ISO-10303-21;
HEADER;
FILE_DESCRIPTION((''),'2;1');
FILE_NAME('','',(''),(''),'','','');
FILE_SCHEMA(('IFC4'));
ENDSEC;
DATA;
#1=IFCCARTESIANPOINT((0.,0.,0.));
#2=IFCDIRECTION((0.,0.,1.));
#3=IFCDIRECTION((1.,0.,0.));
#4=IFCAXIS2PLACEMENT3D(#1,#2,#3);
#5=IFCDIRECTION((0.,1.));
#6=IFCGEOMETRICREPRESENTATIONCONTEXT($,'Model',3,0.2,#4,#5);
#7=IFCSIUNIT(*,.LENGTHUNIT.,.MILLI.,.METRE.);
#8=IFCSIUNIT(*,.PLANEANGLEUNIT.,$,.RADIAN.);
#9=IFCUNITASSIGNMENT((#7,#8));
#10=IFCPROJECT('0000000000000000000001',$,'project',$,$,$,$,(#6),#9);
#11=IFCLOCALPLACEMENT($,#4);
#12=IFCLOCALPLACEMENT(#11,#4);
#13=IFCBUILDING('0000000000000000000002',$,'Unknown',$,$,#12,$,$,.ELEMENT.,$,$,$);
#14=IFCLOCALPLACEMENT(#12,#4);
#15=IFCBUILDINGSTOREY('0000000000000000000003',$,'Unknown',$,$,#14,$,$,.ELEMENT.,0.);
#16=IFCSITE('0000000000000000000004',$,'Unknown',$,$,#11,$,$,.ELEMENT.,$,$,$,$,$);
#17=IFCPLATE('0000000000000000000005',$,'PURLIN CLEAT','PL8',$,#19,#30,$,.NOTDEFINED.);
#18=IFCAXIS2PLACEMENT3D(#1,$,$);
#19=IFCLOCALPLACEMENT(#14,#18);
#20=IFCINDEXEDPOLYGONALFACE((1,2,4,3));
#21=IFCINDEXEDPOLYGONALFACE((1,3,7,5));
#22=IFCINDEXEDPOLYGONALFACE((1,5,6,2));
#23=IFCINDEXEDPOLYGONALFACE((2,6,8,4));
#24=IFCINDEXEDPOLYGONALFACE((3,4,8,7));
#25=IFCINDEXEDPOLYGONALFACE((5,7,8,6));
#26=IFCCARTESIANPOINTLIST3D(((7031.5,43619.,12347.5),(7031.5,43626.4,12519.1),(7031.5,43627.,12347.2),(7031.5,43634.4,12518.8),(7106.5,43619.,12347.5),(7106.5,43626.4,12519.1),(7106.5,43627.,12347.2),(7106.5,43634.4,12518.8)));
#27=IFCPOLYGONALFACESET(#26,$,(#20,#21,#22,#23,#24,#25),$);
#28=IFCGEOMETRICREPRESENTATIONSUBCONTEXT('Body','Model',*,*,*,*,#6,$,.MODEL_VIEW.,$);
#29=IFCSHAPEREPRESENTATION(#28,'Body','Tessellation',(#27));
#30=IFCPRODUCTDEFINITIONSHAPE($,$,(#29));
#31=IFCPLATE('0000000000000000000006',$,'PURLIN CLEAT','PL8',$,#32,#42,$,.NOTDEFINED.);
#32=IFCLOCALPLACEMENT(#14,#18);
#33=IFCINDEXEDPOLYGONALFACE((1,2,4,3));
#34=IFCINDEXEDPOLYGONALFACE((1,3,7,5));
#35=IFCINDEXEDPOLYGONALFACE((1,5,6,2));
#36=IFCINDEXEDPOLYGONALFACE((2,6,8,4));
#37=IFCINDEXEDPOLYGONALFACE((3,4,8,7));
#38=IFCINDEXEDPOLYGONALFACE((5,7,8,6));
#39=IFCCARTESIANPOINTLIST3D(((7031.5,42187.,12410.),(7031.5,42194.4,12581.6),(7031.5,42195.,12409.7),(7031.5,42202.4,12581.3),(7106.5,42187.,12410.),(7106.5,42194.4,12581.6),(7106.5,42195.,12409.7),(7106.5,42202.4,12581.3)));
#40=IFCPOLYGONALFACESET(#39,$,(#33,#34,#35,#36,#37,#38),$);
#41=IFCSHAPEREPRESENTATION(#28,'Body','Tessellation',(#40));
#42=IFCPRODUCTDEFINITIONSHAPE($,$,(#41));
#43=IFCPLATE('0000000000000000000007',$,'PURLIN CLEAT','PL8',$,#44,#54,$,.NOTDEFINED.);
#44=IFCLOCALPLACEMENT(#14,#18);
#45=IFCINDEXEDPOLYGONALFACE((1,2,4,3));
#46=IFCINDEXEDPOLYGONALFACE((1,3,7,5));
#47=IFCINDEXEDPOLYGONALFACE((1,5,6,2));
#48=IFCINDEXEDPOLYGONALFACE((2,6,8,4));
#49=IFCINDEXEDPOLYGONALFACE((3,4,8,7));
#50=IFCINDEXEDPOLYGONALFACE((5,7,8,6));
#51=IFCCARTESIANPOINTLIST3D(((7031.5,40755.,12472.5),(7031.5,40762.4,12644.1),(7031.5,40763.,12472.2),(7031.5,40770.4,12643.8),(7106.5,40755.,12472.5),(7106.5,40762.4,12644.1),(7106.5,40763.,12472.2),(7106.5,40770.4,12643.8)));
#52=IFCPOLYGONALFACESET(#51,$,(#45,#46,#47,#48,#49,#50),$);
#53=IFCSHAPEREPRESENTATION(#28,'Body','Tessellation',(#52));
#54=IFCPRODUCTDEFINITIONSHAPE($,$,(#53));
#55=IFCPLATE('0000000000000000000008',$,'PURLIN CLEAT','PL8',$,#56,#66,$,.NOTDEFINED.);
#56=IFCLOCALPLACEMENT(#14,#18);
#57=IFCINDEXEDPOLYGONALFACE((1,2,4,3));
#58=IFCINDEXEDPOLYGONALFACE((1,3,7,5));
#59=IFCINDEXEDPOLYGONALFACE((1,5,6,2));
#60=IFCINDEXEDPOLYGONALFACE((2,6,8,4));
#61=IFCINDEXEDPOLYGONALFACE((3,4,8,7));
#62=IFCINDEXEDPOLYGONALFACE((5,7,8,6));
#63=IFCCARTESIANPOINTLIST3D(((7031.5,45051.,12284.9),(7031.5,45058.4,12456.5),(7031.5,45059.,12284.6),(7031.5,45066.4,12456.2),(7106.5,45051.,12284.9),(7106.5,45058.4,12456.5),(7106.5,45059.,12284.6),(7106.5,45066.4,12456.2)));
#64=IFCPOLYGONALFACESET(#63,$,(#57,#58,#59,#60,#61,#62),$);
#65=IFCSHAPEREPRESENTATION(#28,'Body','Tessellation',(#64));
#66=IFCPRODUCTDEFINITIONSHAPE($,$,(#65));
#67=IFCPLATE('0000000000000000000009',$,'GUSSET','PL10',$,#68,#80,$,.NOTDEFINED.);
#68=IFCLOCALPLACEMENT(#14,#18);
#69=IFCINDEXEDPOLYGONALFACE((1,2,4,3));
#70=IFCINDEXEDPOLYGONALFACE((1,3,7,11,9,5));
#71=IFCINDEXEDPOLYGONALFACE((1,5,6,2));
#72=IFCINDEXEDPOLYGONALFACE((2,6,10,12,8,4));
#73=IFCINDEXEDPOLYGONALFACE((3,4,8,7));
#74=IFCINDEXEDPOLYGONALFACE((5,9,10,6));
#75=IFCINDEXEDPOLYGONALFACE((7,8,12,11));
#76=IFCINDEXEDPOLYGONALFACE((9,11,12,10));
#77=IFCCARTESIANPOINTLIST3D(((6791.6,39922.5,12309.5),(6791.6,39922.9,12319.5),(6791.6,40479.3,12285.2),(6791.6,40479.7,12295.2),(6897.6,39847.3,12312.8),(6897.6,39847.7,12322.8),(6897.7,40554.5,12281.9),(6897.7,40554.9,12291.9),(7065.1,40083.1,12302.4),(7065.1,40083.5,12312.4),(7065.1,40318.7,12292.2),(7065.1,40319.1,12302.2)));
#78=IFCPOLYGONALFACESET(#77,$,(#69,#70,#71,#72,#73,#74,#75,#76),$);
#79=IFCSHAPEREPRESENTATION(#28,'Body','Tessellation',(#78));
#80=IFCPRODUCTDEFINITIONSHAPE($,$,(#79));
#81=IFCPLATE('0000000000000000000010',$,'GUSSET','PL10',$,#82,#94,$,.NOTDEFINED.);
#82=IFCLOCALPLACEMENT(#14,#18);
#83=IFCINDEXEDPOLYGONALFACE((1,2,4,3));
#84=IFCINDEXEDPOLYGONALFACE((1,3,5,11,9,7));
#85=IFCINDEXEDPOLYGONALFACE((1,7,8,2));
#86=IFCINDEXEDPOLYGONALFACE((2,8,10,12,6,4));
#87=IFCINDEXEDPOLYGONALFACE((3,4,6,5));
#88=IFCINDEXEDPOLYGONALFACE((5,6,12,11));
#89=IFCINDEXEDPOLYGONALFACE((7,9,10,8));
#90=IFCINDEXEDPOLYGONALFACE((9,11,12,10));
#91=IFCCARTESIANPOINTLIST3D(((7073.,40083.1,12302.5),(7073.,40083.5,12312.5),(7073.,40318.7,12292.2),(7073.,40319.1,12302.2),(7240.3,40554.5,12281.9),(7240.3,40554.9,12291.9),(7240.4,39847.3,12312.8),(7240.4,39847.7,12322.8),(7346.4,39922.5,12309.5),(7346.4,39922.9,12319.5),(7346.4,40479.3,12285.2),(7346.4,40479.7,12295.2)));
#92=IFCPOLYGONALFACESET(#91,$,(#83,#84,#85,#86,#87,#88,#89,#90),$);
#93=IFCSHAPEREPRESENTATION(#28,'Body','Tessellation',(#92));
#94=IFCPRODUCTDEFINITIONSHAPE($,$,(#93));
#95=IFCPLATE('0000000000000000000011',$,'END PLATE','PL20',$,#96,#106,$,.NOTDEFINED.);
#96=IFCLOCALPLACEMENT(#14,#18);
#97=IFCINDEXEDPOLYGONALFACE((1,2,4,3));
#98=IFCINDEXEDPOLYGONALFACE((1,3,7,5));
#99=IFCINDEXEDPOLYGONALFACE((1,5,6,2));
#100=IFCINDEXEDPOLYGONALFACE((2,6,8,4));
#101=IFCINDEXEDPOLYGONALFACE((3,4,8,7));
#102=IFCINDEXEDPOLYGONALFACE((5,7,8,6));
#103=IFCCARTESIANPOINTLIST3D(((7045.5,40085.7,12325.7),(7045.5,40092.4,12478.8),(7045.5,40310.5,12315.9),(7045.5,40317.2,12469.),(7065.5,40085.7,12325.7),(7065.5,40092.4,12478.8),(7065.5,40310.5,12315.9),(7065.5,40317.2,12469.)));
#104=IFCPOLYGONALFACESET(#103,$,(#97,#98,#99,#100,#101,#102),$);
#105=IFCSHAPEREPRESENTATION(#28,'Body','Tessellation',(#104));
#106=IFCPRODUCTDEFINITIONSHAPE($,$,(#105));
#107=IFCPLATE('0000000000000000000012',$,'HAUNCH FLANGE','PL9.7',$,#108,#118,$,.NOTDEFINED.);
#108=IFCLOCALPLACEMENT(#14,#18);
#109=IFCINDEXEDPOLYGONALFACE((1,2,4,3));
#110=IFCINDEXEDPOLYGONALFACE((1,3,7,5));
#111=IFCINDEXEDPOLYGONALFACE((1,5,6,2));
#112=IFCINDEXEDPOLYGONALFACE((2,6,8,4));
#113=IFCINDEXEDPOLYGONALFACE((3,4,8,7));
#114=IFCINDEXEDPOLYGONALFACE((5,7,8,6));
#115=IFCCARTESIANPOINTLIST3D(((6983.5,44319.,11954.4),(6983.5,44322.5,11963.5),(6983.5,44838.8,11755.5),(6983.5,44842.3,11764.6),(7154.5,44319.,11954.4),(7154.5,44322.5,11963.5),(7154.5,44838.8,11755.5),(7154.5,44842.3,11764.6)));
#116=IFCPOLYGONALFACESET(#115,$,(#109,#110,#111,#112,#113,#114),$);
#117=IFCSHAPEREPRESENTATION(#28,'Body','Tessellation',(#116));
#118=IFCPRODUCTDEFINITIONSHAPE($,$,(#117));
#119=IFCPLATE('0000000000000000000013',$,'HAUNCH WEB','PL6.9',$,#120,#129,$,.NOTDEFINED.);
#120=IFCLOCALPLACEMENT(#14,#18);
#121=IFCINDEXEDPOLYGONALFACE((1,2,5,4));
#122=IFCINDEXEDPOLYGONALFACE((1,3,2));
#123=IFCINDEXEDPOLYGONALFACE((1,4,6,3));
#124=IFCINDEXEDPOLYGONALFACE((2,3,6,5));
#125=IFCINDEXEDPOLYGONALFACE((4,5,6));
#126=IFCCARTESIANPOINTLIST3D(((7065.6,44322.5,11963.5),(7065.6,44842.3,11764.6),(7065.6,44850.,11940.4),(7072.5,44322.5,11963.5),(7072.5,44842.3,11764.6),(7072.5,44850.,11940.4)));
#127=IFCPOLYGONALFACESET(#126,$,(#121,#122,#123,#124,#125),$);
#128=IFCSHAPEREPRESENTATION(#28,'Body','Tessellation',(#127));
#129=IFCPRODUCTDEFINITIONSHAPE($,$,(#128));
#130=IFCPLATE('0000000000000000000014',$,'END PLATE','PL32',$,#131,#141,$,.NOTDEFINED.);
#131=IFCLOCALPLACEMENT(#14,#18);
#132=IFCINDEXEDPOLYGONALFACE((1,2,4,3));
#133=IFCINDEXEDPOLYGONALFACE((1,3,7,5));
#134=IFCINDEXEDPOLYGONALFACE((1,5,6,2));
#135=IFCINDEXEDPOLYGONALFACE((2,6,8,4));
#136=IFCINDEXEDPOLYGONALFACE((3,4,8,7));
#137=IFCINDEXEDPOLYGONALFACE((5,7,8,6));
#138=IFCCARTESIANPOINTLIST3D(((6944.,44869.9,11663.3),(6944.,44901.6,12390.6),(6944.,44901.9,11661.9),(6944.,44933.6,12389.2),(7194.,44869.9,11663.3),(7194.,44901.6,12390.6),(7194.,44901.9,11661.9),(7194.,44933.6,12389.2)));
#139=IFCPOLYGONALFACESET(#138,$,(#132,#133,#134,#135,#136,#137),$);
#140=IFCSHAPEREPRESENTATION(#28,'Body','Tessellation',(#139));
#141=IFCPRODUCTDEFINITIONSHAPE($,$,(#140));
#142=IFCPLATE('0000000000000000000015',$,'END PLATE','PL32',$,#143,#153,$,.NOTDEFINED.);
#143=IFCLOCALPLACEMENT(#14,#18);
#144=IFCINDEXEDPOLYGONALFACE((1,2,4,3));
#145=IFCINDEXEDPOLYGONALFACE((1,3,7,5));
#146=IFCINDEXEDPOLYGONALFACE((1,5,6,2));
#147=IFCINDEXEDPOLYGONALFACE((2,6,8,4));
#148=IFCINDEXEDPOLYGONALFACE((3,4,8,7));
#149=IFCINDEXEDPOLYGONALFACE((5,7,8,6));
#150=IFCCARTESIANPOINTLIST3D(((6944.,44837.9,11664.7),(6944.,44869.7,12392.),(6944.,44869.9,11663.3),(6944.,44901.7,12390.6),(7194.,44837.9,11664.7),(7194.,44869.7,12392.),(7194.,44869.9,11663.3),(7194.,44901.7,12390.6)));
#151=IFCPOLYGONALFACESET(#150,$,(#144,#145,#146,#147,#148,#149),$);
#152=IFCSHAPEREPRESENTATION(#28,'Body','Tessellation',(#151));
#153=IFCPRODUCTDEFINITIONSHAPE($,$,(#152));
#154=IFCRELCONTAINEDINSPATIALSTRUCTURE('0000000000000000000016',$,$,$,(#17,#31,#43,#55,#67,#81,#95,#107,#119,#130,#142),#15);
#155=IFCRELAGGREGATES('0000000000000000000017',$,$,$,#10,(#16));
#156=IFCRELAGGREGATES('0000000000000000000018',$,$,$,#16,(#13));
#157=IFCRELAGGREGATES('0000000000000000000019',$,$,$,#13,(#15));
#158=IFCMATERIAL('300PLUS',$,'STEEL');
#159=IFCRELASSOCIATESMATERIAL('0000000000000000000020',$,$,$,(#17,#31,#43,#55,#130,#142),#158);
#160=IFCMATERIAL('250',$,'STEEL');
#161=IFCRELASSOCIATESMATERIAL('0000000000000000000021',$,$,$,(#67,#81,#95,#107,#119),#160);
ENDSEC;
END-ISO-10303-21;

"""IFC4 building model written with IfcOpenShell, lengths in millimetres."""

from ifc_helpers import new_model, si_unit, direction, frame, origin_with_axes, place, context, subcontext, project, spatial, line, indexed_curve, outline, extrude, material, element, save


model = new_model("IFC4")

# Units and contexts
model_context = context("Model", 3, precision=0.2, world=origin_with_axes(), true_north=direction((0.0, 1.0)))
body_context = subcontext(model_context, "Body", "Model", "MODEL_VIEW")
ifc_project = project(units=[si_unit("LENGTHUNIT", "METRE", prefix="MILLI"), si_unit("PLANEANGLEUNIT", "RADIAN")], contexts=[model_context])

# Site, building, storey
site_placement = place(None, origin_with_axes())
site = spatial("IfcSite", under=ifc_project, at=site_placement, Name="Unknown", CompositionType="ELEMENT")
building_placement = place(site_placement, origin_with_axes())
building = spatial("IfcBuilding", under=site, at=building_placement, Name="Unknown", CompositionType="ELEMENT")
storey_placement = place(building_placement, origin_with_axes())
storey = spatial("IfcBuildingStorey", under=building, at=storey_placement, Name="Unknown", CompositionType="ELEMENT", Elevation=0.0)

# Shared definitions
ifc_material_1 = material(Name="300PLUS", Category="STEEL")

# Plates
for number, where, z_axis, x_axis, name in (
    (1, (7031.5, 43623.0, 12347.4), (0.0, -0.999071, 0.043084), (1.0, 0.0, 0.0), "PURLIN CLEAT"),
    (2, (7031.5, 42191.0, 12409.9), (0.0, -0.999071, 0.043084), (1.0, 0.0, 0.0), "PURLIN CLEAT"),
    (3, (7031.5, 40759.0, 12472.4), (0.0, -0.999071, 0.043084), (1.0, 0.0, 0.0), "PURLIN CLEAT"),
    (4, (7031.5, 45055.0, 12284.8), (0.0, -0.999071, 0.043084), (1.0, 0.0, 0.0), "PURLIN CLEAT"),
):
    element("IfcPlate", number, at=place(storey_placement, frame(where, z_axis=z_axis, x_axis=x_axis)), inside=storey, material=ifc_material_1, Name=name, Description="PL8", PredefinedType="NOTDEFINED", context=body_context, shape_type="SolidModel", body=[
        extrude(outline(indexed_curve([(0.0, 0.0), (75.0, 0.0), (75.0, 171.8), (0.0, 171.8)], segments=[line(1, 2, 3, 4, 1)])), frame((0.0, 0.0, 4.0), z_axis=(0.0, 0.0, 1.0), x_axis=(1.0, 0.0, 0.0)), (0.0, 0.0, -1.0), 8.0),
    ])
ifc_material_2 = material(Name="250", Category="STEEL")
plate_1_placement = place(storey_placement, frame((6791.6, 40479.5, 12290.2), z_axis=(0.00017, 0.043601, 0.999049), x_axis=(0.0, -0.999049, 0.043601)))
element("IfcPlate", 5, at=plate_1_placement, inside=storey, material=ifc_material_2, Name="GUSSET", Description="PL10", PredefinedType="NOTDEFINED", context=body_context, shape_type="SolidModel", body=[
    extrude(outline(indexed_curve([(0.0, 0.0), (557.3, 0.0), (632.6, 106.0), (396.6, 273.5), (160.8, 273.5), (-75.3, 106.1)], segments=[line(1, 2, 3, 4, 5, 6, 1)])), frame((0.0, 0.0, 5.0), z_axis=(0.0, 0.0, 1.0), x_axis=(1.0, 0.0, 0.0)), (0.0, 0.0, -1.0), 10.0),
])
plate_2_placement = place(storey_placement, frame((7073.0, 40318.9, 12297.2), z_axis=(-0.000052, 0.043676, 0.999046), x_axis=(0.0, -0.999046, 0.043676)))
element("IfcPlate", 6, at=plate_2_placement, inside=storey, material=ifc_material_2, Name="GUSSET", Description="PL10", PredefinedType="NOTDEFINED", context=body_context, shape_type="SolidModel", body=[
    extrude(outline(indexed_curve([(0.0, 0.0), (235.8, 0.0), (471.8, 167.4), (396.6, 273.4), (-160.8, 273.4), (-236.0, 167.3)], segments=[line(1, 2, 3, 4, 5, 6, 1)])), frame((0.0, 0.0, 5.0), z_axis=(0.0, 0.0, 1.0), x_axis=(1.0, 0.0, 0.0)), (0.0, 0.0, -1.0), 10.0),
])
plate_3_placement = place(storey_placement, frame((7055.5, 40310.5, 12315.9), z_axis=(-1.0, 0.0, 0.0), x_axis=(0.0, -0.999051, 0.043553)))
element("IfcPlate", 7, at=plate_3_placement, inside=storey, material=ifc_material_2, Name="END PLATE", Description="PL20", PredefinedType="NOTDEFINED", context=body_context, shape_type="SolidModel", body=[
    extrude(outline(indexed_curve([(0.0, 0.0), (225.0, 0.0), (225.0, 153.2), (0.0, 153.2)], segments=[line(1, 2, 3, 4, 1)])), frame((0.0, 0.0, 10.0), z_axis=(0.0, 0.0, 1.0), x_axis=(1.0, 0.0, 0.0)), (0.0, 0.0, -1.0), 20.0),
])
plate_4_placement = place(storey_placement, frame((6983.5, 44840.5, 11760.0), z_axis=(0.0, 0.357377, 0.93396), x_axis=(0.0, -0.93396, 0.357377)))
element("IfcPlate", 8, at=plate_4_placement, inside=storey, material=ifc_material_2, Name="HAUNCH FLANGE", Description="PL9.7", PredefinedType="NOTDEFINED", context=body_context, shape_type="SolidModel", body=[
    extrude(outline(indexed_curve([(0.0, 0.0), (556.6, 0.0), (556.6, 171.0), (0.0, 171.0)], segments=[line(1, 2, 3, 4, 1)])), frame((0.0, 0.0, 4.8), z_axis=(0.0, 0.0, 1.0), x_axis=(1.0, 0.0, 0.0)), (0.0, 0.0, -1.0), 9.7),
])
plate_5_placement = place(storey_placement, frame((7069.1, 44850.0, 11940.4), z_axis=(-1.0, 0.0, 0.0), x_axis=(0.0, -0.043758, -0.999042)))
element("IfcPlate", 9, at=plate_5_placement, inside=storey, material=ifc_material_2, Name="HAUNCH WEB", Description="PL6.9", PredefinedType="NOTDEFINED", context=body_context, shape_type="SolidModel", body=[
    extrude(outline(indexed_curve([(0.0, 0.0), (176.0, 0.0), (0.0, 528.0)], segments=[line(1, 2, 3, 1)])), frame((0.0, 0.0, 3.5), z_axis=(0.0, 0.0, 1.0), x_axis=(1.0, 0.0, 0.0)), (0.0, 0.0, -1.0), 6.9),
])
plate_6_placement = place(storey_placement, frame((7194.0, 44917.6, 12389.9), z_axis=(0.0, -0.999051, 0.043545), x_axis=(-1.0, 0.0, 0.0)))
element("IfcPlate", 10, at=plate_6_placement, inside=storey, material=ifc_material_1, Name="END PLATE", Description="PL32", PredefinedType="NOTDEFINED", context=body_context, shape_type="SolidModel", body=[
    extrude(outline(indexed_curve([(0.0, 0.0), (250.0, 0.0), (250.0, 728.0), (0.0, 728.0)], segments=[line(1, 2, 3, 4, 1)])), frame((0.0, 0.0, 16.0), z_axis=(0.0, 0.0, 1.0), x_axis=(1.0, 0.0, 0.0)), (0.0, 0.0, -1.0), 32.0),
])
plate_7_placement = place(storey_placement, frame((7194.0, 44885.7, 12391.3), z_axis=(0.0, -0.999046, 0.043682), x_axis=(-1.0, 0.0, 0.0)))
element("IfcPlate", 11, at=plate_7_placement, inside=storey, material=ifc_material_1, Name="END PLATE", Description="PL32", PredefinedType="NOTDEFINED", context=body_context, shape_type="SolidModel", body=[
    extrude(outline(indexed_curve([(0.0, 0.0), (250.0, 0.0), (250.0, 728.0), (0.0, 728.0)], segments=[line(1, 2, 3, 4, 1)])), frame((0.0, 0.0, 16.0), z_axis=(0.0, 0.0, 1.0), x_axis=(1.0, 0.0, 0.0)), (0.0, 0.0, -1.0), 32.0),
])

save(model, "model.ifc")
